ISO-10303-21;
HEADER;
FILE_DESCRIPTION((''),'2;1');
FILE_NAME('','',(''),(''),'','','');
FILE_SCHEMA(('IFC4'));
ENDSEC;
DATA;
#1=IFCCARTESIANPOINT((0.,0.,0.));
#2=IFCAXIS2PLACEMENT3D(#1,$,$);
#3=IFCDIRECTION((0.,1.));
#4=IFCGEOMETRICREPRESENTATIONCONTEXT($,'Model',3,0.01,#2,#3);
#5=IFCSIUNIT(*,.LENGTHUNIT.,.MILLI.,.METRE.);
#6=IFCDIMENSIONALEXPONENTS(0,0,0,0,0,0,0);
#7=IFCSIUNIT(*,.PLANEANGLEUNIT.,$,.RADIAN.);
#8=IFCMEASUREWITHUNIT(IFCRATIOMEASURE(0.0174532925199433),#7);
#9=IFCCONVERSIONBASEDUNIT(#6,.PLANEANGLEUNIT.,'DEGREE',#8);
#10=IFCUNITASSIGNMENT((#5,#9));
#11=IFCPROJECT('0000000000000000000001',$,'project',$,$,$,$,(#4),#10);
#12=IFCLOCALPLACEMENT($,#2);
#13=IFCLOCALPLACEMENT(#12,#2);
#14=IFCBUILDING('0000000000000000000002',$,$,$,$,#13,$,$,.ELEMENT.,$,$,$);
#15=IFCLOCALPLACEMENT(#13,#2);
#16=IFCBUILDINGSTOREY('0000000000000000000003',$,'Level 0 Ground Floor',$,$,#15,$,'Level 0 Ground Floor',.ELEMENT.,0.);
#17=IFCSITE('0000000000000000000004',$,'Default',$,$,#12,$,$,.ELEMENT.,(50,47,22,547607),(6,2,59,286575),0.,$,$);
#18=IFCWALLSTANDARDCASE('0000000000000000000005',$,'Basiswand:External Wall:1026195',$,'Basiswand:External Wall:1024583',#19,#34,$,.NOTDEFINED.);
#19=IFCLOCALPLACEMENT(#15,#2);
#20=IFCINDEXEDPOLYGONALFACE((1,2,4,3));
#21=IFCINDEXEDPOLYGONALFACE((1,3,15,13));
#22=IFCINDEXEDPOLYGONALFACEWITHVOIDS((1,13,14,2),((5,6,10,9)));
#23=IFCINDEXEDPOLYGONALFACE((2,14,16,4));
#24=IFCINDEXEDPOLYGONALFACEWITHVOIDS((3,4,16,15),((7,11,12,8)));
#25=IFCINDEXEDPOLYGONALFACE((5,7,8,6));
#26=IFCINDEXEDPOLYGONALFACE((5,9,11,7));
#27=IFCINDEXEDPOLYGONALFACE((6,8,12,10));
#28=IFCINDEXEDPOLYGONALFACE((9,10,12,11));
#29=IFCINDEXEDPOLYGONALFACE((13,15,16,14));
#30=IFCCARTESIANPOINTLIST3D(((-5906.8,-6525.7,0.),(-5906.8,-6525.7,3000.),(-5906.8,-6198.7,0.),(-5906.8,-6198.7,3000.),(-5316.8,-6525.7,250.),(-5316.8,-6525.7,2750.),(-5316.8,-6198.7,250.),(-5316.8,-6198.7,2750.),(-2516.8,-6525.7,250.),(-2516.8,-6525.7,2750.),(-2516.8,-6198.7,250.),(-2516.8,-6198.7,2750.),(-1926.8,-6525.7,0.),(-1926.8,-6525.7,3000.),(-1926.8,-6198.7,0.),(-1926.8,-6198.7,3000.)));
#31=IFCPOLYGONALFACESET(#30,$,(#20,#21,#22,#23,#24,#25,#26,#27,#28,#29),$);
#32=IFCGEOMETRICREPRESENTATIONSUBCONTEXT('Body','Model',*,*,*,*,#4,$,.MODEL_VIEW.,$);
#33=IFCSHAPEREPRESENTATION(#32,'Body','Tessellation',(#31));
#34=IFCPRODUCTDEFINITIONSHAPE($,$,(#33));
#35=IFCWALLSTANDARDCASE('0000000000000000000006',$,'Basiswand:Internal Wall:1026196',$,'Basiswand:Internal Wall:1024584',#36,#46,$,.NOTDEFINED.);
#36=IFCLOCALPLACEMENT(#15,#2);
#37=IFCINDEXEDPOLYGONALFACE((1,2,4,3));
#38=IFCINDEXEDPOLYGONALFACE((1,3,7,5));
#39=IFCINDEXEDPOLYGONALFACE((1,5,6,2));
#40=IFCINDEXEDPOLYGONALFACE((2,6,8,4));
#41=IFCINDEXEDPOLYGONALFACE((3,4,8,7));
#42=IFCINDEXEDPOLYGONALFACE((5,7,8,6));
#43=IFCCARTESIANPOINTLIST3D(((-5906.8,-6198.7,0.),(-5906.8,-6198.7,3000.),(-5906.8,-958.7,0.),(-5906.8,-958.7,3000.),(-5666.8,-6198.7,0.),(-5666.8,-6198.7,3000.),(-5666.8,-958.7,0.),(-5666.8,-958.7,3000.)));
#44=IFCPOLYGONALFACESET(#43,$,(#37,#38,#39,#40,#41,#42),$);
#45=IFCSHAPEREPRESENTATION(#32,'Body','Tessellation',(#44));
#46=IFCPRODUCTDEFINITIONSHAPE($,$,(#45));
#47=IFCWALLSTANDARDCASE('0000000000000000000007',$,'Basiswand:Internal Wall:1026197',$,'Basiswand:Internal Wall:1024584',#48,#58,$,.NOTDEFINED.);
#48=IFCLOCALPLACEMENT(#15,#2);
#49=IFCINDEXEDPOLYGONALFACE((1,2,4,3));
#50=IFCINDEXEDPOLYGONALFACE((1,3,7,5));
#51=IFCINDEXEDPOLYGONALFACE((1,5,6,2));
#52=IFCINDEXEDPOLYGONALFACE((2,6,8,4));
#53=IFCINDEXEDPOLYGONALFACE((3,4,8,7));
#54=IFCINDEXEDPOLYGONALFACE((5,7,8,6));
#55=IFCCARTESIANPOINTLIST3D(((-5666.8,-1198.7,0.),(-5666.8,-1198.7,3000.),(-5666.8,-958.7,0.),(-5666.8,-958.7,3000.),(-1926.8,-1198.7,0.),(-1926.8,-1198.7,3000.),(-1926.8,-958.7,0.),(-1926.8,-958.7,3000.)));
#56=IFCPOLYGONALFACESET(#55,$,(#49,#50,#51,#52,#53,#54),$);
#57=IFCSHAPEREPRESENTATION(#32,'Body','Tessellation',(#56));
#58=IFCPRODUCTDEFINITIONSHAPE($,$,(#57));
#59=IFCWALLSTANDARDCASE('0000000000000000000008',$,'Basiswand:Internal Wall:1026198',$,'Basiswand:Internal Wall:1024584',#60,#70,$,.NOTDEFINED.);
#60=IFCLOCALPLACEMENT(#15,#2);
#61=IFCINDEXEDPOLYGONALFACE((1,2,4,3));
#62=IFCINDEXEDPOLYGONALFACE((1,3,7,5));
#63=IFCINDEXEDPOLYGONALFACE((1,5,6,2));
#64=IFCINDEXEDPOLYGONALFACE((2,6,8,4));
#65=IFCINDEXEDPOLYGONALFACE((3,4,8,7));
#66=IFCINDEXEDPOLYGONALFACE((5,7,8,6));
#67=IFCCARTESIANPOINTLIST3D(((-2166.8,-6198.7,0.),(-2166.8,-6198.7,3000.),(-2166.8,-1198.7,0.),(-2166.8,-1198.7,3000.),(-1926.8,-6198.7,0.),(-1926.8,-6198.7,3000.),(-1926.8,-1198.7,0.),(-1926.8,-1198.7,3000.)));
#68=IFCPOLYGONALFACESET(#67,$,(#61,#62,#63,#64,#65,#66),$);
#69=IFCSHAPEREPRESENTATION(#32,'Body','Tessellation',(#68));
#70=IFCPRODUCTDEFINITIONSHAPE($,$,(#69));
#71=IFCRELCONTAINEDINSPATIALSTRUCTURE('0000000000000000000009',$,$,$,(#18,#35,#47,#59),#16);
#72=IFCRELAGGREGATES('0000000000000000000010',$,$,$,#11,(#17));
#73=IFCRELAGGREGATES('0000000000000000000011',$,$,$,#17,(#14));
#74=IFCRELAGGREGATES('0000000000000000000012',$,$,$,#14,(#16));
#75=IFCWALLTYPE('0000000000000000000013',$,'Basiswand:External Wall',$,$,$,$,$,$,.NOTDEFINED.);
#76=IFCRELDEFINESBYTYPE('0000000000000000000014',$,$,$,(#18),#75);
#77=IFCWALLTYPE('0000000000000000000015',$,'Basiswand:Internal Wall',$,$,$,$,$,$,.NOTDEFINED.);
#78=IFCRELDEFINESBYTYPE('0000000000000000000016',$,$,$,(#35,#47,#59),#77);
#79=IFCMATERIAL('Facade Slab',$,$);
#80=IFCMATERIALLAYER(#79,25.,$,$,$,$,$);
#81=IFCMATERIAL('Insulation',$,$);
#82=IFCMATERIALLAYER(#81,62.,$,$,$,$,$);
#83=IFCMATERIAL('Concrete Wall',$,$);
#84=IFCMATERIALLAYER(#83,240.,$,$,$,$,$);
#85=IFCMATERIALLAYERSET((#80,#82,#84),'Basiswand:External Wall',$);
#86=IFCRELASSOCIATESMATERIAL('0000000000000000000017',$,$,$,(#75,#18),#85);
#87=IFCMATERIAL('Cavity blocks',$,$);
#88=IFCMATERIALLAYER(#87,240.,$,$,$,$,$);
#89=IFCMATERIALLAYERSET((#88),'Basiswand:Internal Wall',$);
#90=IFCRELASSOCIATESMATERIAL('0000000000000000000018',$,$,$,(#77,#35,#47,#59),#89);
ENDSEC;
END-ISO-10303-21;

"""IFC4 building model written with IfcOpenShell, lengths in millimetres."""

from ifc_helpers import new_model, entity, si_unit, converted_unit, direction, frame, frame_2d, origin, place, context, subcontext, project, spatial, polyline, rectangle, extrude, clip, bounded_halfspace, material, layer, layer_set, layer_usage, type_object, element, save


model = new_model("IFC4")

# Units and contexts
model_context = context("Model", 3, precision=0.01, world=origin(), true_north=direction((0.0, 1.0)))
body_context = subcontext(model_context, "Body", "Model", "MODEL_VIEW")
ifc_project = project(units=[si_unit("LENGTHUNIT", "METRE", prefix="MILLI"), converted_unit("PLANEANGLEUNIT", "DEGREE", entity("IfcRatioMeasure", 0.0174532925199433), si_unit("PLANEANGLEUNIT", "RADIAN"), dimensions=[0, 0, 0, 0, 0, 0, 0])], contexts=[model_context])

# Site, building, storey
site_placement = place(None, origin())
site = spatial("IfcSite", under=ifc_project, at=site_placement, Name="Default", CompositionType="ELEMENT", RefLatitude=(50, 47, 22, 547607), RefLongitude=(6, 2, 59, 286575), RefElevation=0.0)
building_placement = place(site_placement, origin())
building = spatial("IfcBuilding", under=site, at=building_placement, CompositionType="ELEMENT")
storey_placement = place(building_placement, origin())
storey = spatial("IfcBuildingStorey", under=building, at=storey_placement, Name="Level 0 Ground Floor", LongName="Level 0 Ground Floor", CompositionType="ELEMENT", Elevation=0.0)

# Wall, opening
ifc_material_1 = material(Name="Facade Slab")
ifc_layer_1 = layer(ifc_material_1, 25.0)
ifc_material_2 = material(Name="Insulation")
ifc_layer_2 = layer(ifc_material_2, 62.0)
ifc_material_3 = material(Name="Concrete Wall")
ifc_layer_3 = layer(ifc_material_3, 240.0)
ifc_layer_set_1 = layer_set([ifc_layer_1, ifc_layer_2, ifc_layer_3], Name="Basiswand:External Wall")
ifc_layer_usage_1 = layer_usage(ifc_layer_set_1, "AXIS2", "POSITIVE", -163.5)
wall_type_1 = type_object("IfcWallType", Name="Basiswand:External Wall", PredefinedType="NOTDEFINED", material=ifc_layer_set_1)
wall_1_placement = place(storey_placement, frame((-5906.8, -6362.2, 0.0)))
wall_1 = element("IfcWallStandardCase", 1, at=wall_1_placement, inside=storey, type_object=wall_type_1, material=ifc_layer_usage_1, Name="Basiswand:External Wall:1026195", ObjectType="Basiswand:External Wall:1024583", PredefinedType="NOTDEFINED", context=body_context, shape_type="Clipping", body=[
    clip(extrude(rectangle(XDim=3980.0, YDim=327.0, at=frame_2d((1990.0, 0.0), x_axis=(-1.0, 0.0))), origin(), (0.0, 0.0, 1.0), 3000.0), bounded_halfspace(frame((0.0, -163.5, 3000.0), z_axis=(0.0, 0.0, -1.0), x_axis=(0.0, -1.0, 0.0)), True, frame((0.0, -163.5, 3000.0)), polyline([(0.0, 0.0), (3980.0, 0.0), (3980.0, 327.0), (3740.0, 327.0), (240.0, 327.0), (0.0, 327.0), (0.0, 0.0)]))),
])
opening_placement = place(wall_1_placement, frame((590.0, -163.5, 250.0)))
element("IfcOpeningElement", 2, at=opening_placement, cuts=wall_1, ObjectType="Opening", PredefinedType="OPENING", context=body_context, shape_type="SweptSolid", body=[
    extrude(rectangle(XDim=2500.0, YDim=2800.0, at=frame_2d((1250.0, 1400.0), x_axis=(1.0, 0.0))), frame((0.0, 0.0, 0.0), z_axis=(0.0, 1.0, 0.0), x_axis=(0.0, 0.0, 1.0)), (0.0, 0.0, 1.0), 327.0),
])

# Walls
ifc_material_4 = material(Name="Cavity blocks")
ifc_layer_4 = layer(ifc_material_4, 240.0)
ifc_layer_set_2 = layer_set([ifc_layer_4], Name="Basiswand:Internal Wall")
ifc_layer_usage_2 = layer_usage(ifc_layer_set_2, "AXIS2", "NEGATIVE", 120.0)
wall_type_2 = type_object("IfcWallType", Name="Basiswand:Internal Wall", PredefinedType="NOTDEFINED", material=ifc_layer_set_2)
wall_2_placement = place(storey_placement, frame((-5786.8, -6198.7, 0.0), z_axis=(0.0, 0.0, 1.0), x_axis=(0.0, 1.0, 0.0)))
element("IfcWallStandardCase", 3, at=wall_2_placement, inside=storey, type_object=wall_type_2, material=ifc_layer_usage_2, Name="Basiswand:Internal Wall:1026196", ObjectType="Basiswand:Internal Wall:1024584", PredefinedType="NOTDEFINED", context=body_context, shape_type="Clipping", body=[
    clip(extrude(rectangle(XDim=5240.0, YDim=240.0, at=frame_2d((2620.0, 0.0), x_axis=(-1.0, 0.0))), origin(), (0.0, 0.0, 1.0), 3000.0), bounded_halfspace(frame((0.0, -120.0, 3000.0), z_axis=(0.0, 0.0, -1.0), x_axis=(-1.0, 0.0, 0.0)), True, frame((0.0, -120.0, 3000.0)), polyline([(0.0, 0.0), (5000.0, 0.0), (5240.0, 0.0), (5240.0, 240.0), (0.0, 240.0), (0.0, 0.0)]))),
])
ifc_layer_usage_3 = layer_usage(ifc_layer_set_2, "AXIS2", "NEGATIVE", 120.0)
wall_3_placement = place(storey_placement, frame((-5666.8, -1078.7, 0.0)))
element("IfcWallStandardCase", 4, at=wall_3_placement, inside=storey, type_object=wall_type_2, material=ifc_layer_usage_3, Name="Basiswand:Internal Wall:1026197", ObjectType="Basiswand:Internal Wall:1024584", PredefinedType="NOTDEFINED", context=body_context, shape_type="Clipping", body=[
    clip(extrude(rectangle(XDim=3740.0, YDim=240.0, at=frame_2d((1870.0, 0.0), x_axis=(-1.0, 0.0))), origin(), (0.0, 0.0, 1.0), 3000.0), bounded_halfspace(frame((0.0, -120.0, 3000.0), z_axis=(0.0, 0.0, -1.0), x_axis=(0.0, -1.0, 0.0)), True, frame((0.0, -120.0, 3000.0)), polyline([(0.0, 0.0), (3500.0, 0.0), (3740.0, 0.0), (3740.0, 240.0), (0.0, 240.0), (0.0, 0.0)]))),
])
ifc_layer_usage_4 = layer_usage(ifc_layer_set_2, "AXIS2", "NEGATIVE", 120.0)
wall_4_placement = place(storey_placement, frame((-2046.8, -1198.7, 0.0), z_axis=(0.0, 0.0, 1.0), x_axis=(0.0, -1.0, 0.0)))
element("IfcWallStandardCase", 5, at=wall_4_placement, inside=storey, type_object=wall_type_2, material=ifc_layer_usage_4, Name="Basiswand:Internal Wall:1026198", ObjectType="Basiswand:Internal Wall:1024584", PredefinedType="NOTDEFINED", context=body_context, shape_type="Clipping", body=[
    clip(extrude(rectangle(XDim=5000.0, YDim=240.0, at=frame_2d((2500.0, 0.0), x_axis=(-1.0, 0.0))), origin(), (0.0, 0.0, 1.0), 3000.0), bounded_halfspace(frame((0.0, -120.0, 3000.0), z_axis=(0.0, 0.0, -1.0), x_axis=(1.0, 0.0, 0.0)), True, frame((0.0, -120.0, 3000.0)), polyline([(0.0, 0.0), (5000.0, 0.0), (5000.0, 240.0), (0.0, 240.0), (0.0, 0.0)]))),
])

save(model, "model.ifc")
